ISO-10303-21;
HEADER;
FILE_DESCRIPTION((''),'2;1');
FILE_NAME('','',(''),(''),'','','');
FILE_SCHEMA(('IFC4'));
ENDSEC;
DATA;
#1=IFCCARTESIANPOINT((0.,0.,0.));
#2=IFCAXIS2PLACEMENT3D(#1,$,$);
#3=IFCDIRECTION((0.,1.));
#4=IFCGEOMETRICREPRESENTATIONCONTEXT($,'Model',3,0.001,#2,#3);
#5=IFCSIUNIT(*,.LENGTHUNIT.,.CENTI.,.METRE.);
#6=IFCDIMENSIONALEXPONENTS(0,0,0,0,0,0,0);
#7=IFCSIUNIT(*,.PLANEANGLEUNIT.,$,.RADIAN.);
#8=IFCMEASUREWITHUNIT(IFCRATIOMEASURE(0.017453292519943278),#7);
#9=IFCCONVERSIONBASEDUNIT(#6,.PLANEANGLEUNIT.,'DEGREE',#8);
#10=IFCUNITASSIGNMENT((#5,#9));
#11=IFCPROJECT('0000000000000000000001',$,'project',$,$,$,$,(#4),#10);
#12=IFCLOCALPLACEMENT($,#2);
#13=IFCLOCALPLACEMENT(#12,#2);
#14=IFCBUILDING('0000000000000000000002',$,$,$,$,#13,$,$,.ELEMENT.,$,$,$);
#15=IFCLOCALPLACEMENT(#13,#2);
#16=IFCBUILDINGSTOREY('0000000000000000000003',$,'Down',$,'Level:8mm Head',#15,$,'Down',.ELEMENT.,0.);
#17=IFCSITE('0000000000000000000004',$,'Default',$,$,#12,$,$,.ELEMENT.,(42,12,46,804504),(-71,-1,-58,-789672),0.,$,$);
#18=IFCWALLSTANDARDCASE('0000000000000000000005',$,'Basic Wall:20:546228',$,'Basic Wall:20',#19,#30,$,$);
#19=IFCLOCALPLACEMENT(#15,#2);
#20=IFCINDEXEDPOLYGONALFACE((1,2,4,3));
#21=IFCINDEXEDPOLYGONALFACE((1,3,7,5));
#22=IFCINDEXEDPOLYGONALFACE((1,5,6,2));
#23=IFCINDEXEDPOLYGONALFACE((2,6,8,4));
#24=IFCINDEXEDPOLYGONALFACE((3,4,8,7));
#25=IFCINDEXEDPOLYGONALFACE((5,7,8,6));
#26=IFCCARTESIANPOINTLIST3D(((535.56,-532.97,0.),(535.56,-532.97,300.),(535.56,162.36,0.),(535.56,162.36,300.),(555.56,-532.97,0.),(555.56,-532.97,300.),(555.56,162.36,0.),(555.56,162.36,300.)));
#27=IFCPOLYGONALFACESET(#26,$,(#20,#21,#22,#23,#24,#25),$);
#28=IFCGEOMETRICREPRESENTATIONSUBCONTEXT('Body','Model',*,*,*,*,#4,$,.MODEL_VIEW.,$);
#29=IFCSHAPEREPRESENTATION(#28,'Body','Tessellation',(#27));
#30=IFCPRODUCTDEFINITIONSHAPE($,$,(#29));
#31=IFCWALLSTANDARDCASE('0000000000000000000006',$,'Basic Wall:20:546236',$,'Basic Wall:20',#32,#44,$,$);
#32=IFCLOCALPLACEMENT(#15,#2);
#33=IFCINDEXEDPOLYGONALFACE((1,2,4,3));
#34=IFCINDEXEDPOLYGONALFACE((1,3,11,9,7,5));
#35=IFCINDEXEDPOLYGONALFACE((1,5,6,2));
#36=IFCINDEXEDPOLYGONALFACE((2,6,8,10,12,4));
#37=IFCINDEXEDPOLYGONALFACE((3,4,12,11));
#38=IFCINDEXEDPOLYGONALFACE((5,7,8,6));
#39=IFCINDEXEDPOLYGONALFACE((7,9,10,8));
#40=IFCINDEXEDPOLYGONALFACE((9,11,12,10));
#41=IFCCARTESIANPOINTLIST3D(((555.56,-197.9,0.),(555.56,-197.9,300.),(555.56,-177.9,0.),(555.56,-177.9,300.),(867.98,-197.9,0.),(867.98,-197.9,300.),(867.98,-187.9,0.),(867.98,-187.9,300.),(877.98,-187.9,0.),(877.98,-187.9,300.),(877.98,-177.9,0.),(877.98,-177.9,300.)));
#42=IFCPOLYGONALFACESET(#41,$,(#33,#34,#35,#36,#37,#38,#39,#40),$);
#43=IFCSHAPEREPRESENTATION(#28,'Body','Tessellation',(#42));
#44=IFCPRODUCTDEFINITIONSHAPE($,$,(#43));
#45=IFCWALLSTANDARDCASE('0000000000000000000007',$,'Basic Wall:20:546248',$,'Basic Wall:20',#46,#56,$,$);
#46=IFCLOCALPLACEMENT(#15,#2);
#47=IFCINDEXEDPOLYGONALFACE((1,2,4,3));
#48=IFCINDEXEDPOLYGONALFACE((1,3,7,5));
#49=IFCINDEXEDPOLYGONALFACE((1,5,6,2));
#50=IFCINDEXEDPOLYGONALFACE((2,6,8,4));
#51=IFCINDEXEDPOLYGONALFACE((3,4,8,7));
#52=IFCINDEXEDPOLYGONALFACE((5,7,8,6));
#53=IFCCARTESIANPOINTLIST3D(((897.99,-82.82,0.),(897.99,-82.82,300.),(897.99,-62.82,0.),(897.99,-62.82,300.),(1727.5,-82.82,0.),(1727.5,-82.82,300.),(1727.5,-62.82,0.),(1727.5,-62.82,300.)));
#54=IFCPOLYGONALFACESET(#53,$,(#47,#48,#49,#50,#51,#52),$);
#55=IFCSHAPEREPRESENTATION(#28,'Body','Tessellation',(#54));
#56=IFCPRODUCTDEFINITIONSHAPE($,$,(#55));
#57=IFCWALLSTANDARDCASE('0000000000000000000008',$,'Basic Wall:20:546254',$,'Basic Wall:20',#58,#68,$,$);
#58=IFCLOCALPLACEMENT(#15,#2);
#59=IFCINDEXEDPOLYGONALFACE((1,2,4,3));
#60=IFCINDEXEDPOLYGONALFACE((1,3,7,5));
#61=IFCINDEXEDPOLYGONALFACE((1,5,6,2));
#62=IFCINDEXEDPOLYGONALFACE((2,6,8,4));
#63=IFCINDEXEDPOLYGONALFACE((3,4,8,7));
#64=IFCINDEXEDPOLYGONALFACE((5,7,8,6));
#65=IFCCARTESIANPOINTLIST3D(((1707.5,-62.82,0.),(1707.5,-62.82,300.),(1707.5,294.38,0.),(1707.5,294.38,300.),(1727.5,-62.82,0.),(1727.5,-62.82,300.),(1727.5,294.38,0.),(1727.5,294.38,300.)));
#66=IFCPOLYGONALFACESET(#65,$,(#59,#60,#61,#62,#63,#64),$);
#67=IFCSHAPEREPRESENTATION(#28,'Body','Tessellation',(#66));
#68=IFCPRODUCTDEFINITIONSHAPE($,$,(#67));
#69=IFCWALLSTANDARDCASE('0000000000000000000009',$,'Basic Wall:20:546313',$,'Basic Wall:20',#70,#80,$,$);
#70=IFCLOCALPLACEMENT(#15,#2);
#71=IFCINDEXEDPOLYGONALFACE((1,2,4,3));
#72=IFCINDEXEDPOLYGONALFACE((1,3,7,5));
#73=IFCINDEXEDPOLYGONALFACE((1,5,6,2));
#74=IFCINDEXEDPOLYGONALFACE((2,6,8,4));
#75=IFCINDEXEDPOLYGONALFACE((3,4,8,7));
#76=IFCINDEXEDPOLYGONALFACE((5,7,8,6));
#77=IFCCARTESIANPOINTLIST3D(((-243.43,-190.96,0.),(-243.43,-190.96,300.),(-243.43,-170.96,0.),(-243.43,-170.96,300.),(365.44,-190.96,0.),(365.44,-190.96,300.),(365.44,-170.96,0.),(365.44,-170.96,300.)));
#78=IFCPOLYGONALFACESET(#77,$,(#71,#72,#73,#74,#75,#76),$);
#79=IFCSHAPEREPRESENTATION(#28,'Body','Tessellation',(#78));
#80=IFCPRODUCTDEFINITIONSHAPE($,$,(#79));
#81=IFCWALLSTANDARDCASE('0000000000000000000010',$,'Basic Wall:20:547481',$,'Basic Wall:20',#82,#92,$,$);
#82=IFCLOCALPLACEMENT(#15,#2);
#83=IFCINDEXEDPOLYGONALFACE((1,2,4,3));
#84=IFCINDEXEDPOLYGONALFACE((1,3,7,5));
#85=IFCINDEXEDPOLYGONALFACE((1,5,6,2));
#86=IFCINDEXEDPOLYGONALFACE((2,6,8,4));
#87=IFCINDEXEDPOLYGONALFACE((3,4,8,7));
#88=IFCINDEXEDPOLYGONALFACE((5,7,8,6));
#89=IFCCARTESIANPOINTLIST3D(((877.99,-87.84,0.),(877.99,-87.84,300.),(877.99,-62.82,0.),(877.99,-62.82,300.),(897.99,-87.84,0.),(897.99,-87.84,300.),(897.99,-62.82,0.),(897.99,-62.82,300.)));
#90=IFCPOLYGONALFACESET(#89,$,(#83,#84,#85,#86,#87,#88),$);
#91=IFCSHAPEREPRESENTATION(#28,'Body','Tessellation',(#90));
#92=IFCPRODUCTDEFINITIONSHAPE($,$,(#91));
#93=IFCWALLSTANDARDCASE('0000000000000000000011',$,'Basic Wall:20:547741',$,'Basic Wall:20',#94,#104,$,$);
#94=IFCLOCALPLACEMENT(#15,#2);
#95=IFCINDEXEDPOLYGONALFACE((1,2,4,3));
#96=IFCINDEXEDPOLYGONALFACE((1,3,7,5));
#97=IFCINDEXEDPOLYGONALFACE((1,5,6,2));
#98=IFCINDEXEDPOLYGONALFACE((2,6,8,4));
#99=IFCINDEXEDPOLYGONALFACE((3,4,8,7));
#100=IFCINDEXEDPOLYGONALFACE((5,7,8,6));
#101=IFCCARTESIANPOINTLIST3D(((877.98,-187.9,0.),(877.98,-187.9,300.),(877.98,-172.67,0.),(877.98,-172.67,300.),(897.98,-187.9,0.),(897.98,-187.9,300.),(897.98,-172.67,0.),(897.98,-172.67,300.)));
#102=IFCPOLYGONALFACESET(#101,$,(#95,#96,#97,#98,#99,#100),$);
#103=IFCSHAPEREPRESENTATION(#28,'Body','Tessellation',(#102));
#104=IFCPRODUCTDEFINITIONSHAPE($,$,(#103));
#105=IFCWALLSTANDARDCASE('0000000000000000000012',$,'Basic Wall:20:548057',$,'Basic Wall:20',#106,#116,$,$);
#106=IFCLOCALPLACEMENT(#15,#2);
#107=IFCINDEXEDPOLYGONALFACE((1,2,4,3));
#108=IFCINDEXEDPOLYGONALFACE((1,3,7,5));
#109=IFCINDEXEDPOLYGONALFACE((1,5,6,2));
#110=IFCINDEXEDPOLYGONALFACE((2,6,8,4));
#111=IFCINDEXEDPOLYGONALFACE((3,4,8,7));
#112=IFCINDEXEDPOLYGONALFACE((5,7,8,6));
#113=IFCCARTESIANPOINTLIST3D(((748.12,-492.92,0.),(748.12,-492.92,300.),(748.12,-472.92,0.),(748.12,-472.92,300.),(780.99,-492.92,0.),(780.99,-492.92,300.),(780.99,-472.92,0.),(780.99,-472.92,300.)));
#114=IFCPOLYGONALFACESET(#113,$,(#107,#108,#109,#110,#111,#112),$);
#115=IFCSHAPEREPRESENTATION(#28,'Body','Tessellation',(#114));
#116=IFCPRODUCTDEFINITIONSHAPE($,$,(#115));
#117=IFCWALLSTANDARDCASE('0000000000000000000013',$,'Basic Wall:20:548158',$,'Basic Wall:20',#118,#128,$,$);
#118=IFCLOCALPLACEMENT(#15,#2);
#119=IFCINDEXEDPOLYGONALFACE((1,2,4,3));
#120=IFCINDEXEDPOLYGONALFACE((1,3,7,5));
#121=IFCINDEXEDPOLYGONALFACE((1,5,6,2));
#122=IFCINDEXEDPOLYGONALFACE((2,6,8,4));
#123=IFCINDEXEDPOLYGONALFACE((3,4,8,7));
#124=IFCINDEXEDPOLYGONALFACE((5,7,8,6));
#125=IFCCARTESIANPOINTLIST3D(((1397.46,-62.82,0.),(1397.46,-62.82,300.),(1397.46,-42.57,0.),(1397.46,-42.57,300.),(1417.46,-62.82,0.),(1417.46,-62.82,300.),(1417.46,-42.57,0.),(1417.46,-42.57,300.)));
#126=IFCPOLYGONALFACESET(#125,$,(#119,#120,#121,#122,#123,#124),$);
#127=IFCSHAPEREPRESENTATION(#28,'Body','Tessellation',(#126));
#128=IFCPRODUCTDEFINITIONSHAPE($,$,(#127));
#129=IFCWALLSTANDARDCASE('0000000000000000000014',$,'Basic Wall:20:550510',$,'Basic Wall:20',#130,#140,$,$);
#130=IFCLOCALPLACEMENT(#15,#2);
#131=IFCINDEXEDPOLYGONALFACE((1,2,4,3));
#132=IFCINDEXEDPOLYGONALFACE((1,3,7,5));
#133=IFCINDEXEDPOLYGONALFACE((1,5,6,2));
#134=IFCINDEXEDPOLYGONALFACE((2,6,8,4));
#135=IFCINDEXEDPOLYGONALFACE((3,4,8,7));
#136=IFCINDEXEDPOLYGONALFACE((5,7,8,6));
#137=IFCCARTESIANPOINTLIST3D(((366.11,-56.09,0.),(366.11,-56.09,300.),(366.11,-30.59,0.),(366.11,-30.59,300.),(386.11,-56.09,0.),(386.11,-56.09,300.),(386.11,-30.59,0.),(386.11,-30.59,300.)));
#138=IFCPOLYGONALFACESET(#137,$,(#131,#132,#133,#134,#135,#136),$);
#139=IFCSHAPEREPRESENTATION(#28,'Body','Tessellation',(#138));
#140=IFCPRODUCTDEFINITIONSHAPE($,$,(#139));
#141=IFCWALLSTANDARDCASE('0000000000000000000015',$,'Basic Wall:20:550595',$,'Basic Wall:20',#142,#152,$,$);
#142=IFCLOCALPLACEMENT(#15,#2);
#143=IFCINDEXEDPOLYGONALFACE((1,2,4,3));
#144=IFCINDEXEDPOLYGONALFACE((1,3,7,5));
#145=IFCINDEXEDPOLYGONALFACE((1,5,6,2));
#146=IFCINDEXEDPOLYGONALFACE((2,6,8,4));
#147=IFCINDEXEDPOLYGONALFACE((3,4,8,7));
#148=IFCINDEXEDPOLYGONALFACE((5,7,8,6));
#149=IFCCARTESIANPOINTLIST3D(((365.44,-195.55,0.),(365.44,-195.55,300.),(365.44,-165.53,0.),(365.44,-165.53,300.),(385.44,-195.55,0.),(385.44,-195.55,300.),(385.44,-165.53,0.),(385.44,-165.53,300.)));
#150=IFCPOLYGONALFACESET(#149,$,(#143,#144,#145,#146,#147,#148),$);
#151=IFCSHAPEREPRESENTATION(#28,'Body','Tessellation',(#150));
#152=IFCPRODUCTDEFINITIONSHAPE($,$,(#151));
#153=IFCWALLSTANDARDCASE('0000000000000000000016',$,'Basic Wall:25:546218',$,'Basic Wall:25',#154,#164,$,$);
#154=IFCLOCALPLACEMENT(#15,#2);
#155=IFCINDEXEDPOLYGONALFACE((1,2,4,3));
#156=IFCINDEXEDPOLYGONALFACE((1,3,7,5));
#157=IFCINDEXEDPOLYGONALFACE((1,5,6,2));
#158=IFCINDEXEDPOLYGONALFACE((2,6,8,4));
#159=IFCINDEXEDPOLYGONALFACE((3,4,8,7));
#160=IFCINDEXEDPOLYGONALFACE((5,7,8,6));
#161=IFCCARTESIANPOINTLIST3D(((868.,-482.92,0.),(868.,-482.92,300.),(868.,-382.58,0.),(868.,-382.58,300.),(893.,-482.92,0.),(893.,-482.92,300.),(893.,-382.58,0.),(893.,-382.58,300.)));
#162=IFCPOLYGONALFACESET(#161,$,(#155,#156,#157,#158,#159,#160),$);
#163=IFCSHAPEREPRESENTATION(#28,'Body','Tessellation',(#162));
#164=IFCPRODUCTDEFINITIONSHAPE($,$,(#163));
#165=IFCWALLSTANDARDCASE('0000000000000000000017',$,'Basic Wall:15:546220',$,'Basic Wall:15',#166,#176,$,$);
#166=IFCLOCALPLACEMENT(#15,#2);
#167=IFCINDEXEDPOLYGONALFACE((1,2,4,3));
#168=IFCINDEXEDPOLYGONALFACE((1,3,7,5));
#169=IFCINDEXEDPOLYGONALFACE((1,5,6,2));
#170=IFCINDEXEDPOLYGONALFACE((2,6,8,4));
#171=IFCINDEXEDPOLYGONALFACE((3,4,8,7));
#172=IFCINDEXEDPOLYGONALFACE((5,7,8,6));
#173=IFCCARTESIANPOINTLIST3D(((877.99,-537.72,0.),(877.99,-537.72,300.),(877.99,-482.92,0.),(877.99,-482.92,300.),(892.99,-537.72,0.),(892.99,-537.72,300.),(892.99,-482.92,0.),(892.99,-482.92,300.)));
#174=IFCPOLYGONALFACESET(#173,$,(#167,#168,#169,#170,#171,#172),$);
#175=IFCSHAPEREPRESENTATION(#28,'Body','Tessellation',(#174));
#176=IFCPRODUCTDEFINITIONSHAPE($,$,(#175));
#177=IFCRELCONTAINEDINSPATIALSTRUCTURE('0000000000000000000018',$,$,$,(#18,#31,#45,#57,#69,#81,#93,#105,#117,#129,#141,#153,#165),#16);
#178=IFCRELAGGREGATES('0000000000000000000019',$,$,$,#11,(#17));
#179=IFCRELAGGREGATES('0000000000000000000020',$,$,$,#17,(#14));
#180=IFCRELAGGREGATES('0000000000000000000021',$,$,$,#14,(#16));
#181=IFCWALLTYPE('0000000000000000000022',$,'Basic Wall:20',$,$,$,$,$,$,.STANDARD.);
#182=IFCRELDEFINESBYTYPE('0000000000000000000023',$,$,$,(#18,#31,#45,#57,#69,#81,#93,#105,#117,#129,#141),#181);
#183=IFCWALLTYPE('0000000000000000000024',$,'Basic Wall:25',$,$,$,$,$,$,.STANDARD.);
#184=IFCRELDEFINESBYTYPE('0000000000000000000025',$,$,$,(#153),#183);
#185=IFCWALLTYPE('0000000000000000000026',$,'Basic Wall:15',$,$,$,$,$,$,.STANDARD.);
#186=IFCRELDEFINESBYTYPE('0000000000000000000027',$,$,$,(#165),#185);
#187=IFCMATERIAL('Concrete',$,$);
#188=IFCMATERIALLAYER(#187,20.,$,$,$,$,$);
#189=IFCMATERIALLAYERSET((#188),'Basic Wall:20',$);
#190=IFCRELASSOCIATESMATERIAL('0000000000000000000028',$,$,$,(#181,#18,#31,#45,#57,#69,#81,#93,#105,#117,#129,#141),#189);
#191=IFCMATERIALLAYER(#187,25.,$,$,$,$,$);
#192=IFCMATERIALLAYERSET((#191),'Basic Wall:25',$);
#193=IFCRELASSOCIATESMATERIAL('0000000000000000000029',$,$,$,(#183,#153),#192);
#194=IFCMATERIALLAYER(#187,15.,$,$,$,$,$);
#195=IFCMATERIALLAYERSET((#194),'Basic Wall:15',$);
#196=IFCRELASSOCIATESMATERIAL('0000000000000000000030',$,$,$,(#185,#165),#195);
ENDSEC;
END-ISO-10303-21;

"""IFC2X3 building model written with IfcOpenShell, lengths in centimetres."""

from ifc_helpers import new_model, entity, si_unit, converted_unit, direction, frame, frame_2d, origin, place, context, subcontext, project, spatial, polyline, rectangle, outline, extrude, material, layer, layer_set, layer_usage, type_object, element, save


model = new_model("IFC2X3")

# Units and contexts
model_context = context("Model", 3, precision=0.001, world=origin(), true_north=direction((0.0, 1.0)))
body_context = subcontext(model_context, "Body", "Model", "MODEL_VIEW")
ifc_project = project(units=[si_unit("LENGTHUNIT", "METRE", prefix="CENTI"), converted_unit("PLANEANGLEUNIT", "DEGREE", entity("IfcRatioMeasure", 0.017453292519943278), si_unit("PLANEANGLEUNIT", "RADIAN"), dimensions=[0, 0, 0, 0, 0, 0, 0])], contexts=[model_context])

# Site, building, storey
site_placement = place(None, origin())
site = spatial("IfcSite", under=ifc_project, at=site_placement, Name="Default", CompositionType="ELEMENT", RefLatitude=(42, 12, 46, 804504), RefLongitude=(-71, -1, -58, -789672), RefElevation=0.0)
building_placement = place(site_placement, origin())
building = spatial("IfcBuilding", under=site, at=building_placement, CompositionType="ELEMENT")
storey_placement = place(building_placement, origin())
storey = spatial("IfcBuildingStorey", under=building, at=storey_placement, Name="Down", ObjectType="Level:8mm Head", LongName="Down", CompositionType="ELEMENT", Elevation=0.0)

# Walls
ifc_material = material(Name="Concrete")
ifc_layer_1 = layer(ifc_material, 20.0)
ifc_layer_set_1 = layer_set([ifc_layer_1], Name="Basic Wall:20")
wall_type_1 = type_object("IfcWallType", Name="Basic Wall:20", PredefinedType="STANDARD", material=ifc_layer_set_1)
ifc_layer_usage_1 = layer_usage(ifc_layer_set_1, "AXIS2", "NEGATIVE", 10.0)
wall_1_placement = place(storey_placement, frame((545.56, -532.97, 0.0), z_axis=(0.0, 0.0, 1.0), x_axis=(0.0, 1.0, 0.0)))
element("IfcWallStandardCase", 1, at=wall_1_placement, inside=storey, type_object=wall_type_1, material=ifc_layer_usage_1, Name="Basic Wall:20:546228", ObjectType="Basic Wall:20", context=body_context, shape_type="SweptSolid", body=[
    extrude(rectangle(XDim=695.34, YDim=20.0, at=frame_2d((347.67, 0.0), x_axis=(-1.0, 0.0))), origin(), (0.0, 0.0, 1.0), 300.0),
])
ifc_layer_usage_2 = layer_usage(ifc_layer_set_1, "AXIS2", "NEGATIVE", 10.0)
wall_2_placement = place(storey_placement, frame((555.56, -187.9, 0.0)))
element("IfcWallStandardCase", 2, at=wall_2_placement, inside=storey, type_object=wall_type_1, material=ifc_layer_usage_2, Name="Basic Wall:20:546236", ObjectType="Basic Wall:20", context=body_context, shape_type="SweptSolid", body=[
    extrude(outline(polyline([(312.42, -10.0), (312.42, 0.0), (322.42, 0.0), (322.42, 10.0), (0.0, 10.0), (0.0, -10.0), (312.42, -10.0)])), origin(), (0.0, 0.0, 1.0), 300.0),
])
ifc_layer_usage_3 = layer_usage(ifc_layer_set_1, "AXIS2", "POSITIVE", -10.0)
wall_3_placement = place(storey_placement, frame((897.99, -72.82, 0.0)))
element("IfcWallStandardCase", 3, at=wall_3_placement, inside=storey, type_object=wall_type_1, material=ifc_layer_usage_3, Name="Basic Wall:20:546248", ObjectType="Basic Wall:20", context=body_context, shape_type="SweptSolid", body=[
    extrude(rectangle(XDim=829.51, YDim=20.0, at=frame_2d((414.76, 0.0), x_axis=(-1.0, 0.0))), origin(), (0.0, 0.0, 1.0), 300.0),
])
ifc_layer_usage_4 = layer_usage(ifc_layer_set_1, "AXIS2", "POSITIVE", -10.0)
wall_4_placement = place(storey_placement, frame((1717.5, -62.82, 0.0), z_axis=(0.0, 0.0, 1.0), x_axis=(0.0, 1.0, 0.0)))
element("IfcWallStandardCase", 4, at=wall_4_placement, inside=storey, type_object=wall_type_1, material=ifc_layer_usage_4, Name="Basic Wall:20:546254", ObjectType="Basic Wall:20", context=body_context, shape_type="SweptSolid", body=[
    extrude(rectangle(XDim=357.2, YDim=20.0, at=frame_2d((178.6, 0.0), x_axis=(-1.0, 0.0))), origin(), (0.0, 0.0, 1.0), 300.0),
])
ifc_layer_usage_5 = layer_usage(ifc_layer_set_1, "AXIS2", "POSITIVE", -10.0)
wall_5_placement = place(storey_placement, frame((365.44, -180.96, 0.0), z_axis=(0.0, 0.0, 1.0), x_axis=(-1.0, 0.0, 0.0)))
element("IfcWallStandardCase", 5, at=wall_5_placement, inside=storey, type_object=wall_type_1, material=ifc_layer_usage_5, Name="Basic Wall:20:546313", ObjectType="Basic Wall:20", context=body_context, shape_type="SweptSolid", body=[
    extrude(rectangle(XDim=608.87, YDim=20.0, at=frame_2d((304.43, 0.0), x_axis=(-1.0, 0.0))), origin(), (0.0, 0.0, 1.0), 300.0),
])
ifc_layer_usage_6 = layer_usage(ifc_layer_set_1, "AXIS2", "POSITIVE", -10.0)
wall_6_placement = place(storey_placement, frame((887.99, -62.82, 0.0), z_axis=(0.0, 0.0, 1.0), x_axis=(0.0, -1.0, 0.0)))
element("IfcWallStandardCase", 6, at=wall_6_placement, inside=storey, type_object=wall_type_1, material=ifc_layer_usage_6, Name="Basic Wall:20:547481", ObjectType="Basic Wall:20", context=body_context, shape_type="SweptSolid", body=[
    extrude(rectangle(XDim=25.02, YDim=20.0, at=frame_2d((12.51, 0.0), x_axis=(-1.0, 0.0))), origin(), (0.0, 0.0, 1.0), 300.0),
])
ifc_layer_usage_7 = layer_usage(ifc_layer_set_1, "AXIS2", "NEGATIVE", 10.0)
wall_7_placement = place(storey_placement, frame((887.98, -172.67, 0.0), z_axis=(0.0, 0.0, 1.0), x_axis=(0.0, -1.0, 0.0)))
element("IfcWallStandardCase", 7, at=wall_7_placement, inside=storey, type_object=wall_type_1, material=ifc_layer_usage_7, Name="Basic Wall:20:547741", ObjectType="Basic Wall:20", context=body_context, shape_type="SweptSolid", body=[
    extrude(rectangle(XDim=15.23, YDim=20.0, at=frame_2d((7.61, 0.0), x_axis=(-1.0, 0.0))), origin(), (0.0, 0.0, 1.0), 300.0),
])
ifc_layer_usage_8 = layer_usage(ifc_layer_set_1, "AXIS2", "NEGATIVE", 10.0)
wall_8_placement = place(storey_placement, frame((748.12, -482.92, 0.0)))
element("IfcWallStandardCase", 8, at=wall_8_placement, inside=storey, type_object=wall_type_1, material=ifc_layer_usage_8, Name="Basic Wall:20:548057", ObjectType="Basic Wall:20", context=body_context, shape_type="SweptSolid", body=[
    extrude(rectangle(XDim=32.87, YDim=20.0, at=frame_2d((16.44, 0.0), x_axis=(-1.0, 0.0))), origin(), (0.0, 0.0, 1.0), 300.0),
])
ifc_layer_usage_9 = layer_usage(ifc_layer_set_1, "AXIS2", "POSITIVE", -10.0)
wall_9_placement = place(storey_placement, frame((1407.46, -42.57, 0.0), z_axis=(0.0, 0.0, 1.0), x_axis=(0.0, -1.0, 0.0)))
element("IfcWallStandardCase", 9, at=wall_9_placement, inside=storey, type_object=wall_type_1, material=ifc_layer_usage_9, Name="Basic Wall:20:548158", ObjectType="Basic Wall:20", context=body_context, shape_type="SweptSolid", body=[
    extrude(rectangle(XDim=20.25, YDim=20.0, at=frame_2d((10.13, 0.0), x_axis=(-1.0, 0.0))), origin(), (0.0, 0.0, 1.0), 300.0),
])
ifc_layer_usage_10 = layer_usage(ifc_layer_set_1, "AXIS2", "NEGATIVE", 10.0)
wall_10_placement = place(storey_placement, frame((376.11, -30.59, 0.0), z_axis=(0.0, 0.0, 1.0), x_axis=(0.0, -1.0, 0.0)))
element("IfcWallStandardCase", 10, at=wall_10_placement, inside=storey, type_object=wall_type_1, material=ifc_layer_usage_10, Name="Basic Wall:20:550510", ObjectType="Basic Wall:20", context=body_context, shape_type="SweptSolid", body=[
    extrude(rectangle(XDim=25.5, YDim=20.0, at=frame_2d((12.75, 0.0), x_axis=(-1.0, 0.0))), origin(), (0.0, 0.0, 1.0), 300.0),
])
ifc_layer_usage_11 = layer_usage(ifc_layer_set_1, "AXIS2", "NEGATIVE", 10.0)
wall_11_placement = place(storey_placement, frame((375.44, -165.53, 0.0), z_axis=(0.0, 0.0, 1.0), x_axis=(0.0, -1.0, 0.0)))
element("IfcWallStandardCase", 11, at=wall_11_placement, inside=storey, type_object=wall_type_1, material=ifc_layer_usage_11, Name="Basic Wall:20:550595", ObjectType="Basic Wall:20", context=body_context, shape_type="SweptSolid", body=[
    extrude(rectangle(XDim=30.02, YDim=20.0, at=frame_2d((15.01, 0.0), x_axis=(-1.0, 0.0))), origin(), (0.0, 0.0, 1.0), 300.0),
])
ifc_layer_2 = layer(ifc_material, 25.0)
ifc_layer_set_2 = layer_set([ifc_layer_2], Name="Basic Wall:25")
ifc_layer_usage_12 = layer_usage(ifc_layer_set_2, "AXIS2", "POSITIVE", -12.5)
wall_type_2 = type_object("IfcWallType", Name="Basic Wall:25", PredefinedType="STANDARD", material=ifc_layer_set_2)
wall_12_placement = place(storey_placement, frame((880.5, -382.58, 0.0), z_axis=(0.0, 0.0, 1.0), x_axis=(0.0, -1.0, 0.0)))
element("IfcWallStandardCase", 12, at=wall_12_placement, inside=storey, type_object=wall_type_2, material=ifc_layer_usage_12, Name="Basic Wall:25:546218", ObjectType="Basic Wall:25", context=body_context, shape_type="SweptSolid", body=[
    extrude(rectangle(XDim=100.35, YDim=25.0, at=frame_2d((50.17, 0.0), x_axis=(-1.0, 0.0))), origin(), (0.0, 0.0, 1.0), 300.0),
])
ifc_layer_3 = layer(ifc_material, 15.0)
ifc_layer_set_3 = layer_set([ifc_layer_3], Name="Basic Wall:15")
ifc_layer_usage_13 = layer_usage(ifc_layer_set_3, "AXIS2", "POSITIVE", -7.5)
wall_type_3 = type_object("IfcWallType", Name="Basic Wall:15", PredefinedType="STANDARD", material=ifc_layer_set_3)
wall_13_placement = place(storey_placement, frame((885.49, -537.72, 0.0), z_axis=(0.0, 0.0, 1.0), x_axis=(0.0, 1.0, 0.0)))
element("IfcWallStandardCase", 13, at=wall_13_placement, inside=storey, type_object=wall_type_3, material=ifc_layer_usage_13, Name="Basic Wall:15:546220", ObjectType="Basic Wall:15", context=body_context, shape_type="SweptSolid", body=[
    extrude(rectangle(XDim=54.8, YDim=15.0, at=frame_2d((27.4, 0.0), x_axis=(-1.0, 0.0))), origin(), (0.0, 0.0, 1.0), 300.0),
])

save(model, "model.ifc")
